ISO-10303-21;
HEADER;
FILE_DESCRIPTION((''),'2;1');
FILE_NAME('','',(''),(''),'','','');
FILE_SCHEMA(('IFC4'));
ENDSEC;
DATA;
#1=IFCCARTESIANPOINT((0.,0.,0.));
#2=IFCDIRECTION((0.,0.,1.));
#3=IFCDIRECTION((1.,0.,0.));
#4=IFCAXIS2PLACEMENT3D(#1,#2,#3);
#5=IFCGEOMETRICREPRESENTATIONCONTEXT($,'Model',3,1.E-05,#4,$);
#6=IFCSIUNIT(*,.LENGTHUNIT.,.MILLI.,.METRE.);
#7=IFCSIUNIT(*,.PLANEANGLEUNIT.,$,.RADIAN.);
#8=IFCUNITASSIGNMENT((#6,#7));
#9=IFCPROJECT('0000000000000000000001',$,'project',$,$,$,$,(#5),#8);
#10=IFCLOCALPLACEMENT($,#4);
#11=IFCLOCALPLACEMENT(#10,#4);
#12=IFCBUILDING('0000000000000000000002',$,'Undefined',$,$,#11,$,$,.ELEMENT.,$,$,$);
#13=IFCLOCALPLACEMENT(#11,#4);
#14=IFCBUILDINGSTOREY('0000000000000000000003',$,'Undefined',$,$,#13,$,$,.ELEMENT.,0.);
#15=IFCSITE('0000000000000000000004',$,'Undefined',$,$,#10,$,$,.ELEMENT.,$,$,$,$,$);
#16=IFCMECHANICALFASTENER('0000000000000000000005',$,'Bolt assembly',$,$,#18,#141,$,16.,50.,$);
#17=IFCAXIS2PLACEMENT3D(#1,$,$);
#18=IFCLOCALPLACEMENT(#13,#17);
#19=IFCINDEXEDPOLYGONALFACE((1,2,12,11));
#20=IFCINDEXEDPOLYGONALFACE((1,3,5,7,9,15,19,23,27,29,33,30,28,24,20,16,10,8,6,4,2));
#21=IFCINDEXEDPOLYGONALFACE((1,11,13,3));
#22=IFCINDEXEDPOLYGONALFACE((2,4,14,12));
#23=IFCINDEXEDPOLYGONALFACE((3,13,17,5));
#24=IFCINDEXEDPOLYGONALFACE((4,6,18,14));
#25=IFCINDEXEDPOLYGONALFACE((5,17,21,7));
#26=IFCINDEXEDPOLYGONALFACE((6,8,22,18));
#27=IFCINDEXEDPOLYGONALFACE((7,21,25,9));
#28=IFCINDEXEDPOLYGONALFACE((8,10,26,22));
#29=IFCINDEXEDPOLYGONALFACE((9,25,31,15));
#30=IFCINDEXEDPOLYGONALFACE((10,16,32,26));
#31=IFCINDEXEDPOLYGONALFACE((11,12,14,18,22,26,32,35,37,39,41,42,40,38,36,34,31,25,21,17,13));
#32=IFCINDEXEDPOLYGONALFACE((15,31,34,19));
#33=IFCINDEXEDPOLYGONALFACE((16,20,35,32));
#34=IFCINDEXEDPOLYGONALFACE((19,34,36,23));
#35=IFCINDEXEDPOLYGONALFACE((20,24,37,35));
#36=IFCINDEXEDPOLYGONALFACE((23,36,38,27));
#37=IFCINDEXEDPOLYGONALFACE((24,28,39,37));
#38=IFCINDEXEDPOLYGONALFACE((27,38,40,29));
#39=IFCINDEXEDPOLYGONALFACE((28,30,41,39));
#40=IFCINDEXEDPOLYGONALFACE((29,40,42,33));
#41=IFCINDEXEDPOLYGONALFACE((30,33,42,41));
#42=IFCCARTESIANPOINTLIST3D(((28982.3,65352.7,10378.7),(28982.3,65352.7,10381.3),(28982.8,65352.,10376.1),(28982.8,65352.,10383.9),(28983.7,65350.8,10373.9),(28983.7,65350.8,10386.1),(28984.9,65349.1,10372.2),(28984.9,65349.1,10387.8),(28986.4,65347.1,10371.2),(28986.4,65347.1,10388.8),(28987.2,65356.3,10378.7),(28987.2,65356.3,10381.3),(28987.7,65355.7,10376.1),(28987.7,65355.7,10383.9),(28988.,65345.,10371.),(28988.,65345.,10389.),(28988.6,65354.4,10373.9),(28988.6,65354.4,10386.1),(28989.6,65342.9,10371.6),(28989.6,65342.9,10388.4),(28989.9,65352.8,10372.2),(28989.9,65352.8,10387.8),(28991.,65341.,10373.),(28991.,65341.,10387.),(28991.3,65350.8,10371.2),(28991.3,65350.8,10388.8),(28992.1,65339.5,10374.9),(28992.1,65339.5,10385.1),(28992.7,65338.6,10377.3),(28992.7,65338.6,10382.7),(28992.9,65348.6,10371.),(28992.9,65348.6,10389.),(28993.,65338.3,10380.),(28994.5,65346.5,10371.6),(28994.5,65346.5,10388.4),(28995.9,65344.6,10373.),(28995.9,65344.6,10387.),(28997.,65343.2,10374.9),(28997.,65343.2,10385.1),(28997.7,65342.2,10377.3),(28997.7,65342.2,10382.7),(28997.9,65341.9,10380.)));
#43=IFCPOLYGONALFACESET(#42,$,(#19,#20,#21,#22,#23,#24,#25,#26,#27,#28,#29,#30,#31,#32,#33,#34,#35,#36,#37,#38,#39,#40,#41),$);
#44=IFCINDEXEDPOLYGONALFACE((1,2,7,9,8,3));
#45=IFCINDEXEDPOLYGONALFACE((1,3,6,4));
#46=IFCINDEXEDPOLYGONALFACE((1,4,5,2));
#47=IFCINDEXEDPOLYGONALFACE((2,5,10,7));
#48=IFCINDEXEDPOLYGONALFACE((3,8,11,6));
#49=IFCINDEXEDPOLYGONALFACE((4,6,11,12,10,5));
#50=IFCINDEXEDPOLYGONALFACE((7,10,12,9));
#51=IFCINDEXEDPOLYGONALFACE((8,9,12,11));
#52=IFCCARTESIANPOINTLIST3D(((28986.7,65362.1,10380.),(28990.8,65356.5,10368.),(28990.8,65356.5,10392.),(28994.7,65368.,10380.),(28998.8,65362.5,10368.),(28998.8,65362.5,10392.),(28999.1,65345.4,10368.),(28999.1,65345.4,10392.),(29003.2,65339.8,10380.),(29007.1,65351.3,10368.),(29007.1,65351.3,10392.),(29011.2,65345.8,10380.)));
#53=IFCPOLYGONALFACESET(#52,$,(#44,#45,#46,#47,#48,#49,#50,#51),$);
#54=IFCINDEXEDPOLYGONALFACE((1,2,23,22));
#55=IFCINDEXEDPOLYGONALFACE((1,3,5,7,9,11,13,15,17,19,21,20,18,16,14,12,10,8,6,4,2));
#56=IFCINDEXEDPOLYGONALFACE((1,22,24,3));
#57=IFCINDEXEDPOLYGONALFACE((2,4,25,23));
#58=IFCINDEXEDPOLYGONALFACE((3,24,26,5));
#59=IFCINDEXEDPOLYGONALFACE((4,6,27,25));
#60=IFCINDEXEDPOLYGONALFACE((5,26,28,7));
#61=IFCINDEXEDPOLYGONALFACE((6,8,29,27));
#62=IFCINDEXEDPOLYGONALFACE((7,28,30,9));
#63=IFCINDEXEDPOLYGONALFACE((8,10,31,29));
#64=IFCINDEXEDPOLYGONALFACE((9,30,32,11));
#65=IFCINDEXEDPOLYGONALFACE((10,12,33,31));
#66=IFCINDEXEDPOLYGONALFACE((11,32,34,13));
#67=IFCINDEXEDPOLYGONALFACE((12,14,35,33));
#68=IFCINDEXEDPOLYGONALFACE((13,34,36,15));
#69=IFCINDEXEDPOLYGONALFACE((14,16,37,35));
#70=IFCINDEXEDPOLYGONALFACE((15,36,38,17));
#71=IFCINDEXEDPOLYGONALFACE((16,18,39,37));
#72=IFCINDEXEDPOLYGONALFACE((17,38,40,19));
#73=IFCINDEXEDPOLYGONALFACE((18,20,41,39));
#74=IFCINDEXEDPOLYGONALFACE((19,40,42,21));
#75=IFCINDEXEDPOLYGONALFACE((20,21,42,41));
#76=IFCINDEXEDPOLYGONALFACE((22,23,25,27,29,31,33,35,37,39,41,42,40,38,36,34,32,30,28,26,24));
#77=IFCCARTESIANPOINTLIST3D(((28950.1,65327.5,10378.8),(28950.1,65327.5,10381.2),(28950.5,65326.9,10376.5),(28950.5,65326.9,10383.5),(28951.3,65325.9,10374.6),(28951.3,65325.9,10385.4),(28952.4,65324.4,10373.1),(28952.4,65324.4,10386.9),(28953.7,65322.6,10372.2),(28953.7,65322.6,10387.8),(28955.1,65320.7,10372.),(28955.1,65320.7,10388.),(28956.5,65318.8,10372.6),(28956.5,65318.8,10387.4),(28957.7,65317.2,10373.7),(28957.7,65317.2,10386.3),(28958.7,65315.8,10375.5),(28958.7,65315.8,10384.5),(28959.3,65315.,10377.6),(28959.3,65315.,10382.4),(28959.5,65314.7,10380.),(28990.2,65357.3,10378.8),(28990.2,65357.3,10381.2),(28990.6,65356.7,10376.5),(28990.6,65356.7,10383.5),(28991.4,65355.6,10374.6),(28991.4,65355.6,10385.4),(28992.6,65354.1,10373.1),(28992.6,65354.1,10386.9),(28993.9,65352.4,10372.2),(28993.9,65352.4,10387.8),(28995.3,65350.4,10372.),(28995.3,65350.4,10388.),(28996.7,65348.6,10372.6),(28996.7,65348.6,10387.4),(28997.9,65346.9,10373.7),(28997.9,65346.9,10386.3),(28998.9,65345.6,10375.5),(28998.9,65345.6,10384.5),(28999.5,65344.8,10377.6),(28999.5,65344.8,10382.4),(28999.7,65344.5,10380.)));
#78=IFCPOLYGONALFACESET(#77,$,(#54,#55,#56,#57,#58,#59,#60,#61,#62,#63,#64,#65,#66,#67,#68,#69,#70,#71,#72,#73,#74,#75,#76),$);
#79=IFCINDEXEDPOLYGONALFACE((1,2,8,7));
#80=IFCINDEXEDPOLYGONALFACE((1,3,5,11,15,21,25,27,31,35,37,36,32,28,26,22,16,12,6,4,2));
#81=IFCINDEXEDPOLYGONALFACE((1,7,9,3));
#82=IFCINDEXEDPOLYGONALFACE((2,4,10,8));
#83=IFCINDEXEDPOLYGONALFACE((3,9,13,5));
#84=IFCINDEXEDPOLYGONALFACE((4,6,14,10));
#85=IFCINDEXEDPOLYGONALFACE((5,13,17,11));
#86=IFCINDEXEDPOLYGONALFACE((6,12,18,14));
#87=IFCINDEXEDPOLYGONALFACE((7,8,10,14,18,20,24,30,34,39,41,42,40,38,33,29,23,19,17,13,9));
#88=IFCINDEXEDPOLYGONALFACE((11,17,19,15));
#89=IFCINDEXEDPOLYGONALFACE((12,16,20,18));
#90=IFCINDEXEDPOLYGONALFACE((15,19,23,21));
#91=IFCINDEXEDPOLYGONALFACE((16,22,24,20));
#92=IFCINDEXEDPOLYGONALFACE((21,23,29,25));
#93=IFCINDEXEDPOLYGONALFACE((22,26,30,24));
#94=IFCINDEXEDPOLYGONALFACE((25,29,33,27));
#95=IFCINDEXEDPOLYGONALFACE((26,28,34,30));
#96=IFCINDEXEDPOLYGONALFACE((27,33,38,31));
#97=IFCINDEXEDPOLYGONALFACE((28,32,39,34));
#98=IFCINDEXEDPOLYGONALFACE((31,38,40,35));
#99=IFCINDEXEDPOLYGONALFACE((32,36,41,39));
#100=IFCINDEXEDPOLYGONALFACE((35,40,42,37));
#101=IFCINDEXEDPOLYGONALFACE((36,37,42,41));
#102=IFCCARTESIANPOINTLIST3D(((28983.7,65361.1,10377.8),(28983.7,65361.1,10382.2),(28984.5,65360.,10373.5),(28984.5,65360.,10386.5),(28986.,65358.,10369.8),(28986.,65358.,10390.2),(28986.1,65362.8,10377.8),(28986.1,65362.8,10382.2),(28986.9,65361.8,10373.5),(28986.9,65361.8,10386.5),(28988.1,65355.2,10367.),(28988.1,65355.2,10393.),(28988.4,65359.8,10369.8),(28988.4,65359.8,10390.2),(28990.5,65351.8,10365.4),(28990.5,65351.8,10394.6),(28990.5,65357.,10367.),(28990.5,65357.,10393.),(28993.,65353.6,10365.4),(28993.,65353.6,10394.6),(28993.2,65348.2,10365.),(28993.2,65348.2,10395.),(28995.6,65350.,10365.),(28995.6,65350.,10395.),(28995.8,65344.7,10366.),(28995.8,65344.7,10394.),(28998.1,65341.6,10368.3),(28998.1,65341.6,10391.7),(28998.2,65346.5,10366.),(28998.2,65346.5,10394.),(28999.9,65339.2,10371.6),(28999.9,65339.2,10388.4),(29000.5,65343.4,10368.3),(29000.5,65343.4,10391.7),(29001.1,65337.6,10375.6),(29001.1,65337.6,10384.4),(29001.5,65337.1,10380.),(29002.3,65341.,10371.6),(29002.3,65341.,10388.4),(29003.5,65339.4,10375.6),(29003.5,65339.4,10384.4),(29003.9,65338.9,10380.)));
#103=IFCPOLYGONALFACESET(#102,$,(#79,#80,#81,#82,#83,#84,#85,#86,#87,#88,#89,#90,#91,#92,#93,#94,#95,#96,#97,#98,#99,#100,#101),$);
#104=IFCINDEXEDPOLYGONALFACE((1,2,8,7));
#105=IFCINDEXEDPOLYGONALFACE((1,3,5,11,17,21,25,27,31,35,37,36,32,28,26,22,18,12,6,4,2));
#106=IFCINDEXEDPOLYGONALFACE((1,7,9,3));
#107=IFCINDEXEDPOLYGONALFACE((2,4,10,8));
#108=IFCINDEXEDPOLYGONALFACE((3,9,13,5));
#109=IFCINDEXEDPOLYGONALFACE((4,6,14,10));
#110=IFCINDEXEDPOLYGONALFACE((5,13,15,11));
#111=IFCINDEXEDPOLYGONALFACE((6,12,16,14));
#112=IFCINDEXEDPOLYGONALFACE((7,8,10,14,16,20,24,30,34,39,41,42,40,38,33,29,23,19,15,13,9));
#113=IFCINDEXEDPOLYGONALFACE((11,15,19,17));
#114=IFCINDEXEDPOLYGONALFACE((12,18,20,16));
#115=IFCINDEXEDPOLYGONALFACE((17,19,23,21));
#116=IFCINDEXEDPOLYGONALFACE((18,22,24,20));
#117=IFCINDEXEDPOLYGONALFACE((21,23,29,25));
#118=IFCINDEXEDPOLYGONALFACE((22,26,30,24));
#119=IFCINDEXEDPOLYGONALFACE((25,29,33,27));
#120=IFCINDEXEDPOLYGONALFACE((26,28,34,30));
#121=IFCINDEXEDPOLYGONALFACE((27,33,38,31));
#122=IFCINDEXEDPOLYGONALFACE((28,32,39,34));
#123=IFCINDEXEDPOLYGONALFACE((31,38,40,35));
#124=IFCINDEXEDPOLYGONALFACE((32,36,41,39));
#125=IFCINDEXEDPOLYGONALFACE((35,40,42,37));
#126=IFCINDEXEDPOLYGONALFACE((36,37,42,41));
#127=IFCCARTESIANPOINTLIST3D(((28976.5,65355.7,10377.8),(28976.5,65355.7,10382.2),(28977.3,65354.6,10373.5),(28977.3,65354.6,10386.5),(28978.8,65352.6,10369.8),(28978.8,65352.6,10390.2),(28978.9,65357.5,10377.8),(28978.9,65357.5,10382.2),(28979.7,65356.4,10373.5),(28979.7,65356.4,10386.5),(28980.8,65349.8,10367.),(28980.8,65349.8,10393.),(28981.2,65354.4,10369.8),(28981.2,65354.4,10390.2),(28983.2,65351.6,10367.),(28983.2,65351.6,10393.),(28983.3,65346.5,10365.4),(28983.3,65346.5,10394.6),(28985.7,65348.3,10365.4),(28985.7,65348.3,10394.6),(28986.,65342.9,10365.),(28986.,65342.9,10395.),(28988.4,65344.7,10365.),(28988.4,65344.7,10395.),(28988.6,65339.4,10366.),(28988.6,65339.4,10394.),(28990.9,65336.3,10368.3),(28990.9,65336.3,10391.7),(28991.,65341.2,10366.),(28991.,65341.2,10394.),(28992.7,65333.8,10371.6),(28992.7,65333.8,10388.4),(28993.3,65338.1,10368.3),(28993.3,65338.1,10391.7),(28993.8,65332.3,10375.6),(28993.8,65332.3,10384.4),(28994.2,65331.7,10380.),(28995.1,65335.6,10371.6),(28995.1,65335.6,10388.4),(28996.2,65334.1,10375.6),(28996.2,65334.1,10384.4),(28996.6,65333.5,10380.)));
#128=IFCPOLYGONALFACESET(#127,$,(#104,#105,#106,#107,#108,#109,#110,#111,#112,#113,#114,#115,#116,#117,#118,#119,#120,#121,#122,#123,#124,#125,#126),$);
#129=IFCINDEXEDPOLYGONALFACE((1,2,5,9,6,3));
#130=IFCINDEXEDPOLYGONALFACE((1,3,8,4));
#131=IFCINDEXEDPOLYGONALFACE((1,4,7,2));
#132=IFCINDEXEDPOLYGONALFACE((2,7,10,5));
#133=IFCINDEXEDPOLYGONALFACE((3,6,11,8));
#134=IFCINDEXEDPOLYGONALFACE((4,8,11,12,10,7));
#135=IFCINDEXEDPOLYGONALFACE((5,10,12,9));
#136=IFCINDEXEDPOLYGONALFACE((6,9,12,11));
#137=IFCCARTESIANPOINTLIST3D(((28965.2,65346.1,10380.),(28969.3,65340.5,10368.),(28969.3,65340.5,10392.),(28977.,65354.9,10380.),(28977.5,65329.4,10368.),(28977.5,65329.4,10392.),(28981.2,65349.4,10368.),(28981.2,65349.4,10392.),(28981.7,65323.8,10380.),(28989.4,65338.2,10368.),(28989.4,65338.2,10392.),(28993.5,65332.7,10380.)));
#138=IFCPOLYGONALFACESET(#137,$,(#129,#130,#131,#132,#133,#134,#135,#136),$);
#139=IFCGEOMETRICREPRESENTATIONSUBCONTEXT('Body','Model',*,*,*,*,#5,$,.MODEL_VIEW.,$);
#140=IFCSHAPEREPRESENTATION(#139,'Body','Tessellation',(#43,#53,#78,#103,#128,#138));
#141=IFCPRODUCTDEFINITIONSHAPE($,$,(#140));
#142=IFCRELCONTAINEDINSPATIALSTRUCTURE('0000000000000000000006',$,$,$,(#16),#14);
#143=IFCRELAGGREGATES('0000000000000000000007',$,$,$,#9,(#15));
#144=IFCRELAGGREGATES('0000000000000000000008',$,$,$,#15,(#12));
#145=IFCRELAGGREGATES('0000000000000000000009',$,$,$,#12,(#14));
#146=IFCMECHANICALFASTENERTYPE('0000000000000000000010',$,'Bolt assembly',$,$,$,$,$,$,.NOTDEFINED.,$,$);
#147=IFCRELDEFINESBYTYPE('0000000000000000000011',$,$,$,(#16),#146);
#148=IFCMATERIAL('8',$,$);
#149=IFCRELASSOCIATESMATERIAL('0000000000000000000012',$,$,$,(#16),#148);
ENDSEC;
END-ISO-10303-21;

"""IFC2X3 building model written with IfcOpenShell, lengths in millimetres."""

from ifc_helpers import new_model, si_unit, frame, origin_with_axes, origin_2d_with_axis, place, context, subcontext, project, spatial, polyline, circle, outline, extrude, source, transform, mapped, material, type_object, element, save


model = new_model("IFC2X3")

# Units and contexts
model_context = context("Model", 3, precision=1e-05, world=origin_with_axes())
body_context = subcontext(model_context, "Body", "Model", "MODEL_VIEW")
ifc_project = project(units=[si_unit("LENGTHUNIT", "METRE", prefix="MILLI"), si_unit("PLANEANGLEUNIT", "RADIAN")], contexts=[model_context])

# Site, building, storey
site_placement = place(None, origin_with_axes())
site = spatial("IfcSite", under=ifc_project, at=site_placement, Name="Undefined", CompositionType="ELEMENT")
building_placement = place(site_placement, origin_with_axes())
building = spatial("IfcBuilding", under=site, at=building_placement, Name="Undefined", CompositionType="ELEMENT")
storey_placement = place(building_placement, origin_with_axes())
storey = spatial("IfcBuildingStorey", under=building, at=storey_placement, Name="Undefined", CompositionType="ELEMENT", Elevation=0.0)

# Shared definitions
ifc_material_1 = material(Name="8")
mechanical_fastener_type = type_object("IfcMechanicalFastenerType", Name="Bolt assembly")

# Mechanical fastener
shared_shape_1 = source(origin_with_axes(), body_context, "Body", "SweptSolid", [
    extrude(circle(Radius=9.0, at=origin_2d_with_axis()), frame((0.0, 0.0, 0.0), z_axis=(0.0, 1.0, 0.0), x_axis=(1.0, 0.0, 0.0)), (0.0, 0.0, 1.0), 6.1),
    extrude(outline(polyline([(13.9, 0.0), (6.9, 12.0), (-6.9, 12.0), (-13.9, 0.0), (-6.9, -12.0), (6.9, -12.0), (13.9, 0.0)])), frame((0.0, -13.0, 0.0), z_axis=(0.0, 1.0, 0.0), x_axis=(1.0, 0.0, 0.0)), (0.0, 0.0, 1.0), 10.0),
    extrude(circle(Radius=8.0, at=origin_2d_with_axis()), frame((0.0, -3.0, 0.0), z_axis=(0.0, 1.0, 0.0), x_axis=(1.0, 0.0, 0.0)), (0.0, 0.0, 1.0), 50.0),
    extrude(circle(Radius=15.0, at=origin_2d_with_axis()), frame((0.0, -3.0, 0.0), z_axis=(0.0, 1.0, 0.0), x_axis=(1.0, 0.0, 0.0)), (0.0, 0.0, 1.0), 3.0),
    extrude(circle(Radius=15.0, at=origin_2d_with_axis()), frame((0.0, 6.0, 0.0), z_axis=(0.0, 1.0, 0.0), x_axis=(1.0, 0.0, 0.0)), (0.0, 0.0, 1.0), 3.0),
    extrude(outline(polyline([(13.9, 0.0), (6.9, 12.0), (-6.9, 12.0), (-13.9, 0.0), (-6.9, -12.0), (6.9, -12.0), (13.9, 0.0)])), frame((0.0, 9.0, 0.0), z_axis=(0.0, 1.0, 0.0), x_axis=(1.0, 0.0, 0.0)), (0.0, 0.0, 1.0), 14.8),
])
mechanical_fastener_placement = place(storey_placement, frame((28992.5, 65349.1, 10380.0), z_axis=(0.0, 0.0, -1.0), x_axis=(0.595445, -0.803396, 0.0)))
element("IfcMechanicalFastener", 1, at=mechanical_fastener_placement, inside=storey, type_object=mechanical_fastener_type, material=ifc_material_1, Name="Bolt assembly", NominalDiameter=16.0, NominalLength=50.0, context=body_context, shape_type="MappedRepresentation", body=[
    mapped(shared_shape_1, transform((0.0, 0.0, 0.0))),
])

save(model, "model.ifc")
